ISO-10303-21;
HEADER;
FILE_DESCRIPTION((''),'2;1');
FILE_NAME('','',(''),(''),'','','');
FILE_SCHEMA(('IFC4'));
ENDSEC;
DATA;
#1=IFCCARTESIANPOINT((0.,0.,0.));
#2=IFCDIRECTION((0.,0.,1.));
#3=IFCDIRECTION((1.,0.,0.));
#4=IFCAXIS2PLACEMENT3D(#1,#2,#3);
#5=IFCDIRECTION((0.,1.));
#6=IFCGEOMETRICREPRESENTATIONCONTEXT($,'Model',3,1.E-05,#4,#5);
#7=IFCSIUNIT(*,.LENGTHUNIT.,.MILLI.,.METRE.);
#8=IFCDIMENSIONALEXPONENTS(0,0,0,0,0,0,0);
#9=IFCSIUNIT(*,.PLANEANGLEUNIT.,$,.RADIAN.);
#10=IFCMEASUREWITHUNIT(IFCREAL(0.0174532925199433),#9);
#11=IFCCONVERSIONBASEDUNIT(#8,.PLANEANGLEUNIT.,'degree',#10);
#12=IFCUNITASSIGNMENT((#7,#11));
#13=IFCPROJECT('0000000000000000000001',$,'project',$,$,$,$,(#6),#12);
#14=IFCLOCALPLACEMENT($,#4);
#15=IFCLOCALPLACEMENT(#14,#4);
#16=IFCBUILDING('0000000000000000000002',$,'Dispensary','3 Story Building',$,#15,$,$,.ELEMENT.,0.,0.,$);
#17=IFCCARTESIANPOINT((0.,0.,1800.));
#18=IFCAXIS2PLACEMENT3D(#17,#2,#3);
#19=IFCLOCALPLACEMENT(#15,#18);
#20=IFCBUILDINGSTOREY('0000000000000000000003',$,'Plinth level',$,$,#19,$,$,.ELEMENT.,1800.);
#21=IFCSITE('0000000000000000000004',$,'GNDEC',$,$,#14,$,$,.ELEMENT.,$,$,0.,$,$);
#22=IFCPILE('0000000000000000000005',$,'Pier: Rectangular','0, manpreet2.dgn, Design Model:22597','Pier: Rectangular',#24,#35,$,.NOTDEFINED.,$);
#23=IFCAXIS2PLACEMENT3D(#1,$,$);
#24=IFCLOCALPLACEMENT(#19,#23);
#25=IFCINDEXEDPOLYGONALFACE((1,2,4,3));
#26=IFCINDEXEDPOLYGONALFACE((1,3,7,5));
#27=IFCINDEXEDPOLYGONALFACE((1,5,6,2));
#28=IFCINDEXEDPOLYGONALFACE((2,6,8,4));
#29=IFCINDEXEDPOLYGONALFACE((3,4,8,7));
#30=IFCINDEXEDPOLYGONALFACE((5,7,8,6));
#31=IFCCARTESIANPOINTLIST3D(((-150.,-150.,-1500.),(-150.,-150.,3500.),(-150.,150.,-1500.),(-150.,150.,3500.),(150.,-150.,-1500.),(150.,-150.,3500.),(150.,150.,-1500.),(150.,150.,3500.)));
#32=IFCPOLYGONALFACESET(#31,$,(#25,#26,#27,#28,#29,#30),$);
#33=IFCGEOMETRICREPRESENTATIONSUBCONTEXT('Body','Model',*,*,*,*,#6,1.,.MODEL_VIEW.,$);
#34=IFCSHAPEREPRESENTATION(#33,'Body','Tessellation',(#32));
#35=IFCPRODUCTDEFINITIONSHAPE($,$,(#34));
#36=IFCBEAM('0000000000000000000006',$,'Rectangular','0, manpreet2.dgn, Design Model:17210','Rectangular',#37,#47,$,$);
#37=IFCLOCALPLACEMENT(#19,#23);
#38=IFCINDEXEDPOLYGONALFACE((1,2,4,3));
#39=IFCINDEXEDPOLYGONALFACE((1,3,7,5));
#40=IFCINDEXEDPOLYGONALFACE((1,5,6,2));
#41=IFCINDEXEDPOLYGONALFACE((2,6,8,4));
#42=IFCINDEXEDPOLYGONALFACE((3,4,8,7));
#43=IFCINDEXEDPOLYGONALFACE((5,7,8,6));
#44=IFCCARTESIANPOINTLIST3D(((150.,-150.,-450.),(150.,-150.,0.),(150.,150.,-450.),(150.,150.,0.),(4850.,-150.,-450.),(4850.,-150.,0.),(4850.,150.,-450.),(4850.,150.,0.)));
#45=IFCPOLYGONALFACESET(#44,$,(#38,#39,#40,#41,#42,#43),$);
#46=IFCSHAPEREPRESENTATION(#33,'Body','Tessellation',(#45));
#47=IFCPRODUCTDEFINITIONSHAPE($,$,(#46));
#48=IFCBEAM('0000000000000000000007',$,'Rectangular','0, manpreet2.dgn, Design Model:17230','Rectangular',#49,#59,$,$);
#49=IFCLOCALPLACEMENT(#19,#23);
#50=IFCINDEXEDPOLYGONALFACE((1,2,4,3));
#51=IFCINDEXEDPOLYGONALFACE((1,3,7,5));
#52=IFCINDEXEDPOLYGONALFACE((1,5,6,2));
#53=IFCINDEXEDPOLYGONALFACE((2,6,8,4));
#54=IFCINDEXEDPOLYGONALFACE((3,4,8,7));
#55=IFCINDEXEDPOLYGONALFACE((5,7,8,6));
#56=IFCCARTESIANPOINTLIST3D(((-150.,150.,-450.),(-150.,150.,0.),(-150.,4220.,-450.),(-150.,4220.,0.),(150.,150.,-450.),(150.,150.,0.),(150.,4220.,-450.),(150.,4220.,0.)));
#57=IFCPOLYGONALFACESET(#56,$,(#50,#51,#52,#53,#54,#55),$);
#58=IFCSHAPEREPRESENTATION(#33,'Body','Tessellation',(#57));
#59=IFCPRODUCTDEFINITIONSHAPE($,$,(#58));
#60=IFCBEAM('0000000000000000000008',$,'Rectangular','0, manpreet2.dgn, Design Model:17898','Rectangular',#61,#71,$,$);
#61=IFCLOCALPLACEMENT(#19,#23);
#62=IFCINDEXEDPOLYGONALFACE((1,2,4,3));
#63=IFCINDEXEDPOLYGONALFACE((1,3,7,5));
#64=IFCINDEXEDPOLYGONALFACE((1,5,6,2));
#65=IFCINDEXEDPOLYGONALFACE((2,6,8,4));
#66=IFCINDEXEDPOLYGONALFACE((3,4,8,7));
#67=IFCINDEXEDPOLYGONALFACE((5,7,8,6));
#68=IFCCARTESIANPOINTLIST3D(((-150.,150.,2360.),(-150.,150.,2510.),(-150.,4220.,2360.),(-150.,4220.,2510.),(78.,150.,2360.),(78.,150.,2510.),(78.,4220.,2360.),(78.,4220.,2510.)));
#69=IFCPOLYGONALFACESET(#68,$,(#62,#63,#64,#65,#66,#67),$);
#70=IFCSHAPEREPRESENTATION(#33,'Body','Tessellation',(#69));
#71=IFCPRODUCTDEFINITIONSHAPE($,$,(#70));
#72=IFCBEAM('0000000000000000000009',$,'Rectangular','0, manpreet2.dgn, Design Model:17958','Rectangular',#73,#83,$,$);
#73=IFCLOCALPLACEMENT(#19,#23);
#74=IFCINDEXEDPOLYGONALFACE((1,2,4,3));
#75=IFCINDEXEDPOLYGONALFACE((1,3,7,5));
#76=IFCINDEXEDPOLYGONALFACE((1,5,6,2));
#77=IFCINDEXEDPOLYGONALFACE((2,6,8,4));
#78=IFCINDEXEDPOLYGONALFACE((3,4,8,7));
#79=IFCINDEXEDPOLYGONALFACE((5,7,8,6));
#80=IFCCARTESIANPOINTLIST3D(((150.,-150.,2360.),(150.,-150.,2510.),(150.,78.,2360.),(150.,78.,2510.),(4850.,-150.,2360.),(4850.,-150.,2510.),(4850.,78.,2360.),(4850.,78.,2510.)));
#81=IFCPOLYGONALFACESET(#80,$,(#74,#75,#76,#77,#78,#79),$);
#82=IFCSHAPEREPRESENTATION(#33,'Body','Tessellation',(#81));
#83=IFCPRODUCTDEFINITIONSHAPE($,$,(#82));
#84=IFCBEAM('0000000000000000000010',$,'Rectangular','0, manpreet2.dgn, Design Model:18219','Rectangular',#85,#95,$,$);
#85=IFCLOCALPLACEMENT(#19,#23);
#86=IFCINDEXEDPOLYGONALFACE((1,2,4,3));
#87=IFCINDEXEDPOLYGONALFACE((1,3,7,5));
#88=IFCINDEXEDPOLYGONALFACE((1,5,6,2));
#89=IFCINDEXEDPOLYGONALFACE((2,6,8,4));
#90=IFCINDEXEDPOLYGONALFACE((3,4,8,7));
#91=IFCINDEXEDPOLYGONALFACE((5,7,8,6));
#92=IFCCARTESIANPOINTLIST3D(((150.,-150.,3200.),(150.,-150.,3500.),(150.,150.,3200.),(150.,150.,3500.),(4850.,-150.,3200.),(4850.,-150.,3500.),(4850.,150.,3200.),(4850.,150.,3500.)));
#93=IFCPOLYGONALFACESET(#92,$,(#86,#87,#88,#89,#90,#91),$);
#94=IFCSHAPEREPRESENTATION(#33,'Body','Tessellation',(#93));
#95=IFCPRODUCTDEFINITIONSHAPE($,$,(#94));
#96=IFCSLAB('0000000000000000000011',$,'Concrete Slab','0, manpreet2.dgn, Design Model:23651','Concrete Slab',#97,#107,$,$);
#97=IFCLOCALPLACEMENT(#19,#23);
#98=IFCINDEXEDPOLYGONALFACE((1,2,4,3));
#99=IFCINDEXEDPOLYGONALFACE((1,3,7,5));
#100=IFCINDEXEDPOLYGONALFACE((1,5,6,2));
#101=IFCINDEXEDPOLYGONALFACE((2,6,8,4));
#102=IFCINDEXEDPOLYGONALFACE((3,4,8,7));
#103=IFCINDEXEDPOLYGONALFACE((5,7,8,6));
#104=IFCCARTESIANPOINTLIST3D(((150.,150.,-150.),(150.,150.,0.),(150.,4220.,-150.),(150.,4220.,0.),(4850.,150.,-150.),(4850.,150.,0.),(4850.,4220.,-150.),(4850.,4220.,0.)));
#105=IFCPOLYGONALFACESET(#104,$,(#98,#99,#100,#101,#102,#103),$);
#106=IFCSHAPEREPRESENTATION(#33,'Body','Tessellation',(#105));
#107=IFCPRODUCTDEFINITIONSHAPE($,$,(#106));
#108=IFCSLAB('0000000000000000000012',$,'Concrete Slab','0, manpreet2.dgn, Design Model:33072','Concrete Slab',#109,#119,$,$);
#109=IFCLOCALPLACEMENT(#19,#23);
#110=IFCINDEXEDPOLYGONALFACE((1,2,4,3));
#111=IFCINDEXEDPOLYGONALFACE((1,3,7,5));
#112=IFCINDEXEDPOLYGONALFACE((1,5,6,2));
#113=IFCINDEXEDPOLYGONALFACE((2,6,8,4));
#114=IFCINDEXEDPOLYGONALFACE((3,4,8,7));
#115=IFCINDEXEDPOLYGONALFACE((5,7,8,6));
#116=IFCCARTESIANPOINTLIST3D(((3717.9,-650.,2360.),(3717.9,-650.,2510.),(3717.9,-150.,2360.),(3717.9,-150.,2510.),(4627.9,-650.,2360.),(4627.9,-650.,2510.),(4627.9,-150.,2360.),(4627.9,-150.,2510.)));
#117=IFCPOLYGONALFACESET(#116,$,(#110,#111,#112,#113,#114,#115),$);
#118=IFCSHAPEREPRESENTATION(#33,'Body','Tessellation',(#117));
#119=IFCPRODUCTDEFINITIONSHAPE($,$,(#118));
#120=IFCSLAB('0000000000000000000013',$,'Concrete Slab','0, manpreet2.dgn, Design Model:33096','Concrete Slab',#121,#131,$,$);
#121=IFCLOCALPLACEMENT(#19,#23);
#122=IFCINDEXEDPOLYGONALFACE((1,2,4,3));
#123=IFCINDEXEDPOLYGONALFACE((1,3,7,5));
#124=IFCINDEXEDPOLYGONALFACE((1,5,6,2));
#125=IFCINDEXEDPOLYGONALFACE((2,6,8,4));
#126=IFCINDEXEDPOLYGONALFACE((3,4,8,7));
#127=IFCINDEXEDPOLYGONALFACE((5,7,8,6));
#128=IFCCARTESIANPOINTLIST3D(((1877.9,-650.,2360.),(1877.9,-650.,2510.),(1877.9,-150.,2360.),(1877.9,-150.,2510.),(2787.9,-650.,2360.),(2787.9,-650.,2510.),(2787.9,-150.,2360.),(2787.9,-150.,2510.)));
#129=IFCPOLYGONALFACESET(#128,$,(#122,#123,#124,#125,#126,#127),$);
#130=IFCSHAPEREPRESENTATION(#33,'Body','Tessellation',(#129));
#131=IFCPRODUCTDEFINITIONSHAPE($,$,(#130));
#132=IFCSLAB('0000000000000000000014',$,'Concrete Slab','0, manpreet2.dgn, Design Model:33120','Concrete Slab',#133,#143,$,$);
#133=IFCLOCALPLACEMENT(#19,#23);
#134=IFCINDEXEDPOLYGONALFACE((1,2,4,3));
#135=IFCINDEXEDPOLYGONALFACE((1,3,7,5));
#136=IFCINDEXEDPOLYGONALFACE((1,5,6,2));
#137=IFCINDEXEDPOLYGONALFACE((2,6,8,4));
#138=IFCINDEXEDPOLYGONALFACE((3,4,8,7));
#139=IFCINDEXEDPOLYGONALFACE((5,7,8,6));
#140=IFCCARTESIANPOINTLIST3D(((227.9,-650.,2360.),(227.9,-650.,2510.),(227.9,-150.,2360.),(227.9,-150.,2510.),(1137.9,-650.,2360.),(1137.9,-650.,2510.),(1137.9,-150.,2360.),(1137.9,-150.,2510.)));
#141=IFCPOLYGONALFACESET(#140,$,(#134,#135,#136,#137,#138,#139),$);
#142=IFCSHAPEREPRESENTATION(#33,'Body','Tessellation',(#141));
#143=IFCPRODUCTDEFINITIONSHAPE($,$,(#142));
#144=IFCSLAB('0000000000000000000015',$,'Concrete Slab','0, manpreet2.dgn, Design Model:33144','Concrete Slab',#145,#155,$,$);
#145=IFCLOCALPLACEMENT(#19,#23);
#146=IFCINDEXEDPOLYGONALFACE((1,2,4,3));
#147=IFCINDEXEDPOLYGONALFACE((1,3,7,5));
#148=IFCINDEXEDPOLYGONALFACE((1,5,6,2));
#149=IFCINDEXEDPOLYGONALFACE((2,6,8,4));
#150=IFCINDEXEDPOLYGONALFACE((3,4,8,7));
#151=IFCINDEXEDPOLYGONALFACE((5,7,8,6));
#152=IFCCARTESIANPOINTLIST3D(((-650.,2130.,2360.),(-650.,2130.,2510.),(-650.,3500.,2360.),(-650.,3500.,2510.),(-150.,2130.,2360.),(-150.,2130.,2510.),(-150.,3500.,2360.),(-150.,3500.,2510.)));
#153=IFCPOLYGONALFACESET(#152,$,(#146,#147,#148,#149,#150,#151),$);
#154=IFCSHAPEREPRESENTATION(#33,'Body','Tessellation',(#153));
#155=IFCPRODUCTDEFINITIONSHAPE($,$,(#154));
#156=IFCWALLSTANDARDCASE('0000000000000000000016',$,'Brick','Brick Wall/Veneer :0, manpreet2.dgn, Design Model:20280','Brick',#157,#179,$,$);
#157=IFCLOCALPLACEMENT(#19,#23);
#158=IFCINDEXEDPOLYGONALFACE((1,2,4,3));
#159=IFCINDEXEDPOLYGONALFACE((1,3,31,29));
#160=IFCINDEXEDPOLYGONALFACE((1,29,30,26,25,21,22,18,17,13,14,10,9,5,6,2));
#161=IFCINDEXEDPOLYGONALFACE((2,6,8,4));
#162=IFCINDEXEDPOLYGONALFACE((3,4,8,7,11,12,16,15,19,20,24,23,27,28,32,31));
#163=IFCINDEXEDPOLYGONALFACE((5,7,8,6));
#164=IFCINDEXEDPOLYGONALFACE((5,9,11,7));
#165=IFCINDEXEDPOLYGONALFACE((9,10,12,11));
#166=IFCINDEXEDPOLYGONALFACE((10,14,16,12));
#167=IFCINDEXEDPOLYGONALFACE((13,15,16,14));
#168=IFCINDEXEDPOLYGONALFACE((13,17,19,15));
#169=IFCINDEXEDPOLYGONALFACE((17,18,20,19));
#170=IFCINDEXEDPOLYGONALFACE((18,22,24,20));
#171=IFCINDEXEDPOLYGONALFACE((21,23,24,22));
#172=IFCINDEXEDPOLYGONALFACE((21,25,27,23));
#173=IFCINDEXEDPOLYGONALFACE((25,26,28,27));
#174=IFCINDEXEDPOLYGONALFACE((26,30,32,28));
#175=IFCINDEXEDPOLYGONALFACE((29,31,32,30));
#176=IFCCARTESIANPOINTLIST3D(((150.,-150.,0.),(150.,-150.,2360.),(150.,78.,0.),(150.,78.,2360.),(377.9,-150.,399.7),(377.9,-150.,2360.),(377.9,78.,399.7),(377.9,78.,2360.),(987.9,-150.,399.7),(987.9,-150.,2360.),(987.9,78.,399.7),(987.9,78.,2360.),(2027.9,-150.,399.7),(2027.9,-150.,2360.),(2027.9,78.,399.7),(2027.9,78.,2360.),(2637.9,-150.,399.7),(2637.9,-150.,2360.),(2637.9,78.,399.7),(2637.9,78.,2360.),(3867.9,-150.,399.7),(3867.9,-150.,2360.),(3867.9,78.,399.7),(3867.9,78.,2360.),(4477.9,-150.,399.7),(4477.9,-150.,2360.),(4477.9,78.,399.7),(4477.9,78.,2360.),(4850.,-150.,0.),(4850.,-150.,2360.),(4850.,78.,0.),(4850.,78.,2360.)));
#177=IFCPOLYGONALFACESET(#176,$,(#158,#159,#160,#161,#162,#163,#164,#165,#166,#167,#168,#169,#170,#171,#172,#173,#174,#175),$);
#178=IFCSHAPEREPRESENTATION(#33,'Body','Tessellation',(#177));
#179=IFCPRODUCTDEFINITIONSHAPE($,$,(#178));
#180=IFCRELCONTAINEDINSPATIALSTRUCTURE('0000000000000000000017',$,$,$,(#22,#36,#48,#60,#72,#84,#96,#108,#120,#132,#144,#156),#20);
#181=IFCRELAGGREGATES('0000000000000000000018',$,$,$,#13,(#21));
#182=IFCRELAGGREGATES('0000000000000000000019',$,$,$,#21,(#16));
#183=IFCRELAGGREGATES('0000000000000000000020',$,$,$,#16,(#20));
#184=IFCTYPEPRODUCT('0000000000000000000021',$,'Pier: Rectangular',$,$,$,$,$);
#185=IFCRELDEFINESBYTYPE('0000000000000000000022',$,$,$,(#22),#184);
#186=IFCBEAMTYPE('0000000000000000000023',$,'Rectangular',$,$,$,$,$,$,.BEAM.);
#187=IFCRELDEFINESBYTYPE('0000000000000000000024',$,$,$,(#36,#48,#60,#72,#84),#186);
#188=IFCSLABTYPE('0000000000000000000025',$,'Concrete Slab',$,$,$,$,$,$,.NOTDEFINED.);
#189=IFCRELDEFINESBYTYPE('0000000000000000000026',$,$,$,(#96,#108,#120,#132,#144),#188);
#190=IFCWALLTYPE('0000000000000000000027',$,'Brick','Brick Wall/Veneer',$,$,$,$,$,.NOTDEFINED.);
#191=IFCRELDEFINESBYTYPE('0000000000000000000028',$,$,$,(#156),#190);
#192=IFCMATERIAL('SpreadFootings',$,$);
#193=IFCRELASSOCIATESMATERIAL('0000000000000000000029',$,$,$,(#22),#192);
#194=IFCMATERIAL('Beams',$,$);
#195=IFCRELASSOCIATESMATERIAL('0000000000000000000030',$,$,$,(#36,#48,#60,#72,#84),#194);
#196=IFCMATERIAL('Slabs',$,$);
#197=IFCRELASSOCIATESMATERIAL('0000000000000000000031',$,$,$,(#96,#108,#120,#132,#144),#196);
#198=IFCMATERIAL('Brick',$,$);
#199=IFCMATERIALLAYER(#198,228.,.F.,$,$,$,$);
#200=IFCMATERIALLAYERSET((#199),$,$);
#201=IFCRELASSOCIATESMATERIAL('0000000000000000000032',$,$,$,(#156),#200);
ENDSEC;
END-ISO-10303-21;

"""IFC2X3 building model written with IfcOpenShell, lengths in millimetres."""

from ifc_helpers import new_model, entity, si_unit, converted_unit, direction, frame, frame_2d, origin_with_axes, place, context, subcontext, project, spatial, rectangle, extrude, material, layer, layer_set, layer_usage, type_object, element, save


model = new_model("IFC2X3")

# Units and contexts
model_context = context("Model", 3, precision=1e-05, world=origin_with_axes(), true_north=direction((0.0, 1.0)))
body_context = subcontext(model_context, "Body", "Model", "MODEL_VIEW", scale=1.0)
ifc_project = project(units=[si_unit("LENGTHUNIT", "METRE", prefix="MILLI"), converted_unit("PLANEANGLEUNIT", "degree", entity("IfcReal", 0.0174532925199433), si_unit("PLANEANGLEUNIT", "RADIAN"), dimensions=[0, 0, 0, 0, 0, 0, 0])], contexts=[model_context])

# Site, building, storey
site_placement = place(None, origin_with_axes())
site = spatial("IfcSite", under=ifc_project, at=site_placement, Name="GNDEC", CompositionType="ELEMENT", RefElevation=0.0)
building_placement = place(site_placement, origin_with_axes())
building = spatial("IfcBuilding", under=site, at=building_placement, Name="Dispensary", Description="3 Story Building", CompositionType="ELEMENT", ElevationOfRefHeight=0.0, ElevationOfTerrain=0.0)
storey_placement = place(building_placement, frame((0.0, 0.0, 1800.0), z_axis=(0.0, 0.0, 1.0), x_axis=(1.0, 0.0, 0.0)))
storey = spatial("IfcBuildingStorey", under=building, at=storey_placement, Name="Plinth level", CompositionType="ELEMENT", Elevation=1800.0)

# Pile
ifc_material_1 = material(Name="SpreadFootings")
type_product = type_object("IfcTypeProduct", Name="Pier: Rectangular")
for number, where, z_axis, x_axis, name in (
    (1, (-150.0, 150.0, -1500.0), (0.0, 0.0, 1.0), (0.0, -1.0, 0.0), "Pier: Rectangular"),
):
    element("IfcPile", number, at=place(storey_placement, frame(where, z_axis=z_axis, x_axis=x_axis)), inside=storey, type_object=type_product, material=ifc_material_1, Name=name, Description="0, manpreet2.dgn, Design Model:22597", ObjectType="Pier: Rectangular", PredefinedType="NOTDEFINED", context=body_context, shape_type="SweptSolid", body=[
        extrude(rectangle(XDim=300.0, YDim=300.0, at=frame_2d((150.0, 150.0), x_axis=(0.0, 1.0))), origin_with_axes(), (0.0, 0.0, 1.0), 5000.0),
    ])

# Beams
ifc_material_2 = material(Name="Beams")
beam_type = type_object("IfcBeamType", Name="Rectangular", PredefinedType="BEAM")
beam_1_placement = place(storey_placement, frame((4850.0, -150.0, -450.0), z_axis=(-1.0, 0.0, 0.0), x_axis=(0.0, 0.0, 1.0)))
element("IfcBeam", 2, at=beam_1_placement, inside=storey, type_object=beam_type, material=ifc_material_2, Name="Rectangular", Description="0, manpreet2.dgn, Design Model:17210", ObjectType="Rectangular", context=body_context, shape_type="SweptSolid", body=[
    extrude(rectangle(XDim=300.0, YDim=450.0, at=frame_2d((225.0, 150.0), x_axis=(0.0, 1.0))), origin_with_axes(), (0.0, 0.0, 1.0), 4700.0),
])
beam_2_placement = place(storey_placement, frame((-150.0, 150.0, -450.0), z_axis=(0.0, 1.0, 0.0), x_axis=(0.0, 0.0, 1.0)))
element("IfcBeam", 3, at=beam_2_placement, inside=storey, type_object=beam_type, material=ifc_material_2, Name="Rectangular", Description="0, manpreet2.dgn, Design Model:17230", ObjectType="Rectangular", context=body_context, shape_type="SweptSolid", body=[
    extrude(rectangle(XDim=300.0, YDim=450.0, at=frame_2d((225.0, 150.0), x_axis=(0.0, 1.0))), origin_with_axes(), (0.0, 0.0, 1.0), 4070.0),
])
beam_3_placement = place(storey_placement, frame((78.0, 150.0, 2360.0), z_axis=(0.0, 1.0, 0.0), x_axis=(-1.0, 0.0, 0.0)))
element("IfcBeam", 4, at=beam_3_placement, inside=storey, type_object=beam_type, material=ifc_material_2, Name="Rectangular", Description="0, manpreet2.dgn, Design Model:17898", ObjectType="Rectangular", context=body_context, shape_type="SweptSolid", body=[
    extrude(rectangle(XDim=150.0, YDim=228.0, at=frame_2d((114.0, 75.0), x_axis=(0.0, 1.0))), origin_with_axes(), (0.0, 0.0, 1.0), 4070.0),
])
beam_4_placement = place(storey_placement, frame((4850.0, 78.0, 2360.0), z_axis=(-1.0, 0.0, 0.0), x_axis=(0.0, -1.0, 0.0)))
element("IfcBeam", 5, at=beam_4_placement, inside=storey, type_object=beam_type, material=ifc_material_2, Name="Rectangular", Description="0, manpreet2.dgn, Design Model:17958", ObjectType="Rectangular", context=body_context, shape_type="SweptSolid", body=[
    extrude(rectangle(XDim=150.0, YDim=228.0, at=frame_2d((114.0, 75.0), x_axis=(0.0, 1.0))), origin_with_axes(), (0.0, 0.0, 1.0), 4700.0),
])
beam_5_placement = place(storey_placement, frame((150.0, -150.0, 3200.0), z_axis=(1.0, 0.0, 0.0), x_axis=(0.0, 1.0, 0.0)))
element("IfcBeam", 6, at=beam_5_placement, inside=storey, type_object=beam_type, material=ifc_material_2, Name="Rectangular", Description="0, manpreet2.dgn, Design Model:18219", ObjectType="Rectangular", context=body_context, shape_type="SweptSolid", body=[
    extrude(rectangle(XDim=300.0, YDim=300.0, at=frame_2d((150.0, 150.0), x_axis=(0.0, 1.0))), origin_with_axes(), (0.0, 0.0, 1.0), 4700.0),
])

# Slabs
ifc_material_3 = material(Name="Slabs")
slab_type = type_object("IfcSlabType", Name="Concrete Slab", PredefinedType="NOTDEFINED")
slab_1_placement = place(storey_placement, frame((150.0, 4220.0, 0.0), z_axis=(0.0, 0.0, -1.0), x_axis=(1.0, 0.0, 0.0)))
element("IfcSlab", 7, at=slab_1_placement, inside=storey, type_object=slab_type, material=ifc_material_3, Name="Concrete Slab", Description="0, manpreet2.dgn, Design Model:23651", ObjectType="Concrete Slab", context=body_context, shape_type="SweptSolid", body=[
    extrude(rectangle(XDim=4700.0, YDim=4070.0, at=frame_2d((2350.0, 2035.0), x_axis=(1.0, 0.0))), origin_with_axes(), (0.0, 0.0, 1.0), 150.0),
])
for number, where, z_axis, x_axis, name, description in (
    (8, (4477.9, -150.0, 2510.0), (0.0, 0.0, -1.0), (1.0, 0.0, 0.0), "Concrete Slab", "0, manpreet2.dgn, Design Model:33072"),
    (9, (2637.9, -150.0, 2510.0), (0.0, 0.0, -1.0), (1.0, 0.0, 0.0), "Concrete Slab", "0, manpreet2.dgn, Design Model:33096"),
    (10, (987.9, -150.0, 2510.0), (0.0, 0.0, -1.0), (1.0, 0.0, 0.0), "Concrete Slab", "0, manpreet2.dgn, Design Model:33120"),
):
    element("IfcSlab", number, at=place(storey_placement, frame(where, z_axis=z_axis, x_axis=x_axis)), inside=storey, type_object=slab_type, material=ifc_material_3, Name=name, Description=description, ObjectType="Concrete Slab", context=body_context, shape_type="SweptSolid", body=[
        extrude(rectangle(XDim=500.0, YDim=910.0, at=frame_2d((-305.0, 250.0), x_axis=(0.0, 1.0))), origin_with_axes(), (0.0, 0.0, 1.0), 150.0),
    ])
slab_2_placement = place(storey_placement, frame((-150.0, 2130.0, 2510.0), z_axis=(0.0, 0.0, -1.0), x_axis=(-1.0, 0.0, 0.0)))
element("IfcSlab", 11, at=slab_2_placement, inside=storey, type_object=slab_type, material=ifc_material_3, Name="Concrete Slab", Description="0, manpreet2.dgn, Design Model:33144", ObjectType="Concrete Slab", context=body_context, shape_type="SweptSolid", body=[
    extrude(rectangle(XDim=500.0, YDim=1370.0, at=frame_2d((250.0, 685.0), x_axis=(1.0, 0.0))), origin_with_axes(), (0.0, 0.0, 1.0), 150.0),
])

# Wall, openings
ifc_material_4 = material(Name="Brick")
ifc_layer = layer(ifc_material_4, 228.0, ventilated=False)
ifc_layer_set = layer_set([ifc_layer])
ifc_layer_usage = layer_usage(ifc_layer_set, "AXIS2", "POSITIVE", 0.0)
wall_type = type_object("IfcWallType", Name="Brick", Description="Brick Wall/Veneer", PredefinedType="NOTDEFINED")
wall_1_placement = place(storey_placement, frame((4850.0, -150.0, 0.0), z_axis=(0.0, 0.0, 1.0), x_axis=(-1.0, 0.0, 0.0)))
wall_1 = element("IfcWallStandardCase", 12, at=wall_1_placement, inside=storey, type_object=wall_type, material=ifc_layer_usage, Name="Brick", Description="Brick Wall/Veneer :0, manpreet2.dgn, Design Model:20280", ObjectType="Brick", context=body_context, shape_type="SweptSolid", body=[
    extrude(rectangle(XDim=4700.0, YDim=228.0, at=frame_2d((2350.0, -114.0), x_axis=(-1.0, 0.0))), origin_with_axes(), (0.0, 0.0, 1.0), 2360.0),
])
opening_1_placement = place(wall_1_placement, frame((3862.1, -228.0, 399.7), z_axis=(0.0, 0.0, 1.0), x_axis=(1.0, 0.0, 0.0)))
element("IfcOpeningElement", 13, at=opening_1_placement, cuts=wall_1, ObjectType="Opening", context=body_context, shape_type="SweptSolid", body=[
    extrude(rectangle(XDim=2720.0, YDim=610.0, at=frame_2d((-305.0, 1360.0), x_axis=(0.0, -1.0))), frame((0.0, 0.0, 0.0), z_axis=(0.0, 1.0, 0.0), x_axis=(-1.0, 0.0, 0.0)), (0.0, 0.0, 1.0), 228.0),
])
opening_2_placement = place(wall_1_placement, frame((2212.1, -228.0, 399.7), z_axis=(0.0, 0.0, 1.0), x_axis=(1.0, 0.0, 0.0)))
element("IfcOpeningElement", 14, at=opening_2_placement, cuts=wall_1, ObjectType="Opening", context=body_context, shape_type="SweptSolid", body=[
    extrude(rectangle(XDim=2720.0, YDim=610.0, at=frame_2d((-305.0, 1360.0), x_axis=(0.0, -1.0))), frame((0.0, 0.0, 0.0), z_axis=(0.0, 1.0, 0.0), x_axis=(-1.0, 0.0, 0.0)), (0.0, 0.0, 1.0), 228.0),
])
opening_3_placement = place(wall_1_placement, frame((372.1, -228.0, 399.7), z_axis=(0.0, 0.0, 1.0), x_axis=(1.0, 0.0, 0.0)))
element("IfcOpeningElement", 15, at=opening_3_placement, cuts=wall_1, ObjectType="Opening", context=body_context, shape_type="SweptSolid", body=[
    extrude(rectangle(XDim=2720.0, YDim=610.0, at=frame_2d((-305.0, 1360.0), x_axis=(0.0, -1.0))), frame((0.0, 0.0, 0.0), z_axis=(0.0, 1.0, 0.0), x_axis=(-1.0, 0.0, 0.0)), (0.0, 0.0, 1.0), 228.0),
])

save(model, "model.ifc")
